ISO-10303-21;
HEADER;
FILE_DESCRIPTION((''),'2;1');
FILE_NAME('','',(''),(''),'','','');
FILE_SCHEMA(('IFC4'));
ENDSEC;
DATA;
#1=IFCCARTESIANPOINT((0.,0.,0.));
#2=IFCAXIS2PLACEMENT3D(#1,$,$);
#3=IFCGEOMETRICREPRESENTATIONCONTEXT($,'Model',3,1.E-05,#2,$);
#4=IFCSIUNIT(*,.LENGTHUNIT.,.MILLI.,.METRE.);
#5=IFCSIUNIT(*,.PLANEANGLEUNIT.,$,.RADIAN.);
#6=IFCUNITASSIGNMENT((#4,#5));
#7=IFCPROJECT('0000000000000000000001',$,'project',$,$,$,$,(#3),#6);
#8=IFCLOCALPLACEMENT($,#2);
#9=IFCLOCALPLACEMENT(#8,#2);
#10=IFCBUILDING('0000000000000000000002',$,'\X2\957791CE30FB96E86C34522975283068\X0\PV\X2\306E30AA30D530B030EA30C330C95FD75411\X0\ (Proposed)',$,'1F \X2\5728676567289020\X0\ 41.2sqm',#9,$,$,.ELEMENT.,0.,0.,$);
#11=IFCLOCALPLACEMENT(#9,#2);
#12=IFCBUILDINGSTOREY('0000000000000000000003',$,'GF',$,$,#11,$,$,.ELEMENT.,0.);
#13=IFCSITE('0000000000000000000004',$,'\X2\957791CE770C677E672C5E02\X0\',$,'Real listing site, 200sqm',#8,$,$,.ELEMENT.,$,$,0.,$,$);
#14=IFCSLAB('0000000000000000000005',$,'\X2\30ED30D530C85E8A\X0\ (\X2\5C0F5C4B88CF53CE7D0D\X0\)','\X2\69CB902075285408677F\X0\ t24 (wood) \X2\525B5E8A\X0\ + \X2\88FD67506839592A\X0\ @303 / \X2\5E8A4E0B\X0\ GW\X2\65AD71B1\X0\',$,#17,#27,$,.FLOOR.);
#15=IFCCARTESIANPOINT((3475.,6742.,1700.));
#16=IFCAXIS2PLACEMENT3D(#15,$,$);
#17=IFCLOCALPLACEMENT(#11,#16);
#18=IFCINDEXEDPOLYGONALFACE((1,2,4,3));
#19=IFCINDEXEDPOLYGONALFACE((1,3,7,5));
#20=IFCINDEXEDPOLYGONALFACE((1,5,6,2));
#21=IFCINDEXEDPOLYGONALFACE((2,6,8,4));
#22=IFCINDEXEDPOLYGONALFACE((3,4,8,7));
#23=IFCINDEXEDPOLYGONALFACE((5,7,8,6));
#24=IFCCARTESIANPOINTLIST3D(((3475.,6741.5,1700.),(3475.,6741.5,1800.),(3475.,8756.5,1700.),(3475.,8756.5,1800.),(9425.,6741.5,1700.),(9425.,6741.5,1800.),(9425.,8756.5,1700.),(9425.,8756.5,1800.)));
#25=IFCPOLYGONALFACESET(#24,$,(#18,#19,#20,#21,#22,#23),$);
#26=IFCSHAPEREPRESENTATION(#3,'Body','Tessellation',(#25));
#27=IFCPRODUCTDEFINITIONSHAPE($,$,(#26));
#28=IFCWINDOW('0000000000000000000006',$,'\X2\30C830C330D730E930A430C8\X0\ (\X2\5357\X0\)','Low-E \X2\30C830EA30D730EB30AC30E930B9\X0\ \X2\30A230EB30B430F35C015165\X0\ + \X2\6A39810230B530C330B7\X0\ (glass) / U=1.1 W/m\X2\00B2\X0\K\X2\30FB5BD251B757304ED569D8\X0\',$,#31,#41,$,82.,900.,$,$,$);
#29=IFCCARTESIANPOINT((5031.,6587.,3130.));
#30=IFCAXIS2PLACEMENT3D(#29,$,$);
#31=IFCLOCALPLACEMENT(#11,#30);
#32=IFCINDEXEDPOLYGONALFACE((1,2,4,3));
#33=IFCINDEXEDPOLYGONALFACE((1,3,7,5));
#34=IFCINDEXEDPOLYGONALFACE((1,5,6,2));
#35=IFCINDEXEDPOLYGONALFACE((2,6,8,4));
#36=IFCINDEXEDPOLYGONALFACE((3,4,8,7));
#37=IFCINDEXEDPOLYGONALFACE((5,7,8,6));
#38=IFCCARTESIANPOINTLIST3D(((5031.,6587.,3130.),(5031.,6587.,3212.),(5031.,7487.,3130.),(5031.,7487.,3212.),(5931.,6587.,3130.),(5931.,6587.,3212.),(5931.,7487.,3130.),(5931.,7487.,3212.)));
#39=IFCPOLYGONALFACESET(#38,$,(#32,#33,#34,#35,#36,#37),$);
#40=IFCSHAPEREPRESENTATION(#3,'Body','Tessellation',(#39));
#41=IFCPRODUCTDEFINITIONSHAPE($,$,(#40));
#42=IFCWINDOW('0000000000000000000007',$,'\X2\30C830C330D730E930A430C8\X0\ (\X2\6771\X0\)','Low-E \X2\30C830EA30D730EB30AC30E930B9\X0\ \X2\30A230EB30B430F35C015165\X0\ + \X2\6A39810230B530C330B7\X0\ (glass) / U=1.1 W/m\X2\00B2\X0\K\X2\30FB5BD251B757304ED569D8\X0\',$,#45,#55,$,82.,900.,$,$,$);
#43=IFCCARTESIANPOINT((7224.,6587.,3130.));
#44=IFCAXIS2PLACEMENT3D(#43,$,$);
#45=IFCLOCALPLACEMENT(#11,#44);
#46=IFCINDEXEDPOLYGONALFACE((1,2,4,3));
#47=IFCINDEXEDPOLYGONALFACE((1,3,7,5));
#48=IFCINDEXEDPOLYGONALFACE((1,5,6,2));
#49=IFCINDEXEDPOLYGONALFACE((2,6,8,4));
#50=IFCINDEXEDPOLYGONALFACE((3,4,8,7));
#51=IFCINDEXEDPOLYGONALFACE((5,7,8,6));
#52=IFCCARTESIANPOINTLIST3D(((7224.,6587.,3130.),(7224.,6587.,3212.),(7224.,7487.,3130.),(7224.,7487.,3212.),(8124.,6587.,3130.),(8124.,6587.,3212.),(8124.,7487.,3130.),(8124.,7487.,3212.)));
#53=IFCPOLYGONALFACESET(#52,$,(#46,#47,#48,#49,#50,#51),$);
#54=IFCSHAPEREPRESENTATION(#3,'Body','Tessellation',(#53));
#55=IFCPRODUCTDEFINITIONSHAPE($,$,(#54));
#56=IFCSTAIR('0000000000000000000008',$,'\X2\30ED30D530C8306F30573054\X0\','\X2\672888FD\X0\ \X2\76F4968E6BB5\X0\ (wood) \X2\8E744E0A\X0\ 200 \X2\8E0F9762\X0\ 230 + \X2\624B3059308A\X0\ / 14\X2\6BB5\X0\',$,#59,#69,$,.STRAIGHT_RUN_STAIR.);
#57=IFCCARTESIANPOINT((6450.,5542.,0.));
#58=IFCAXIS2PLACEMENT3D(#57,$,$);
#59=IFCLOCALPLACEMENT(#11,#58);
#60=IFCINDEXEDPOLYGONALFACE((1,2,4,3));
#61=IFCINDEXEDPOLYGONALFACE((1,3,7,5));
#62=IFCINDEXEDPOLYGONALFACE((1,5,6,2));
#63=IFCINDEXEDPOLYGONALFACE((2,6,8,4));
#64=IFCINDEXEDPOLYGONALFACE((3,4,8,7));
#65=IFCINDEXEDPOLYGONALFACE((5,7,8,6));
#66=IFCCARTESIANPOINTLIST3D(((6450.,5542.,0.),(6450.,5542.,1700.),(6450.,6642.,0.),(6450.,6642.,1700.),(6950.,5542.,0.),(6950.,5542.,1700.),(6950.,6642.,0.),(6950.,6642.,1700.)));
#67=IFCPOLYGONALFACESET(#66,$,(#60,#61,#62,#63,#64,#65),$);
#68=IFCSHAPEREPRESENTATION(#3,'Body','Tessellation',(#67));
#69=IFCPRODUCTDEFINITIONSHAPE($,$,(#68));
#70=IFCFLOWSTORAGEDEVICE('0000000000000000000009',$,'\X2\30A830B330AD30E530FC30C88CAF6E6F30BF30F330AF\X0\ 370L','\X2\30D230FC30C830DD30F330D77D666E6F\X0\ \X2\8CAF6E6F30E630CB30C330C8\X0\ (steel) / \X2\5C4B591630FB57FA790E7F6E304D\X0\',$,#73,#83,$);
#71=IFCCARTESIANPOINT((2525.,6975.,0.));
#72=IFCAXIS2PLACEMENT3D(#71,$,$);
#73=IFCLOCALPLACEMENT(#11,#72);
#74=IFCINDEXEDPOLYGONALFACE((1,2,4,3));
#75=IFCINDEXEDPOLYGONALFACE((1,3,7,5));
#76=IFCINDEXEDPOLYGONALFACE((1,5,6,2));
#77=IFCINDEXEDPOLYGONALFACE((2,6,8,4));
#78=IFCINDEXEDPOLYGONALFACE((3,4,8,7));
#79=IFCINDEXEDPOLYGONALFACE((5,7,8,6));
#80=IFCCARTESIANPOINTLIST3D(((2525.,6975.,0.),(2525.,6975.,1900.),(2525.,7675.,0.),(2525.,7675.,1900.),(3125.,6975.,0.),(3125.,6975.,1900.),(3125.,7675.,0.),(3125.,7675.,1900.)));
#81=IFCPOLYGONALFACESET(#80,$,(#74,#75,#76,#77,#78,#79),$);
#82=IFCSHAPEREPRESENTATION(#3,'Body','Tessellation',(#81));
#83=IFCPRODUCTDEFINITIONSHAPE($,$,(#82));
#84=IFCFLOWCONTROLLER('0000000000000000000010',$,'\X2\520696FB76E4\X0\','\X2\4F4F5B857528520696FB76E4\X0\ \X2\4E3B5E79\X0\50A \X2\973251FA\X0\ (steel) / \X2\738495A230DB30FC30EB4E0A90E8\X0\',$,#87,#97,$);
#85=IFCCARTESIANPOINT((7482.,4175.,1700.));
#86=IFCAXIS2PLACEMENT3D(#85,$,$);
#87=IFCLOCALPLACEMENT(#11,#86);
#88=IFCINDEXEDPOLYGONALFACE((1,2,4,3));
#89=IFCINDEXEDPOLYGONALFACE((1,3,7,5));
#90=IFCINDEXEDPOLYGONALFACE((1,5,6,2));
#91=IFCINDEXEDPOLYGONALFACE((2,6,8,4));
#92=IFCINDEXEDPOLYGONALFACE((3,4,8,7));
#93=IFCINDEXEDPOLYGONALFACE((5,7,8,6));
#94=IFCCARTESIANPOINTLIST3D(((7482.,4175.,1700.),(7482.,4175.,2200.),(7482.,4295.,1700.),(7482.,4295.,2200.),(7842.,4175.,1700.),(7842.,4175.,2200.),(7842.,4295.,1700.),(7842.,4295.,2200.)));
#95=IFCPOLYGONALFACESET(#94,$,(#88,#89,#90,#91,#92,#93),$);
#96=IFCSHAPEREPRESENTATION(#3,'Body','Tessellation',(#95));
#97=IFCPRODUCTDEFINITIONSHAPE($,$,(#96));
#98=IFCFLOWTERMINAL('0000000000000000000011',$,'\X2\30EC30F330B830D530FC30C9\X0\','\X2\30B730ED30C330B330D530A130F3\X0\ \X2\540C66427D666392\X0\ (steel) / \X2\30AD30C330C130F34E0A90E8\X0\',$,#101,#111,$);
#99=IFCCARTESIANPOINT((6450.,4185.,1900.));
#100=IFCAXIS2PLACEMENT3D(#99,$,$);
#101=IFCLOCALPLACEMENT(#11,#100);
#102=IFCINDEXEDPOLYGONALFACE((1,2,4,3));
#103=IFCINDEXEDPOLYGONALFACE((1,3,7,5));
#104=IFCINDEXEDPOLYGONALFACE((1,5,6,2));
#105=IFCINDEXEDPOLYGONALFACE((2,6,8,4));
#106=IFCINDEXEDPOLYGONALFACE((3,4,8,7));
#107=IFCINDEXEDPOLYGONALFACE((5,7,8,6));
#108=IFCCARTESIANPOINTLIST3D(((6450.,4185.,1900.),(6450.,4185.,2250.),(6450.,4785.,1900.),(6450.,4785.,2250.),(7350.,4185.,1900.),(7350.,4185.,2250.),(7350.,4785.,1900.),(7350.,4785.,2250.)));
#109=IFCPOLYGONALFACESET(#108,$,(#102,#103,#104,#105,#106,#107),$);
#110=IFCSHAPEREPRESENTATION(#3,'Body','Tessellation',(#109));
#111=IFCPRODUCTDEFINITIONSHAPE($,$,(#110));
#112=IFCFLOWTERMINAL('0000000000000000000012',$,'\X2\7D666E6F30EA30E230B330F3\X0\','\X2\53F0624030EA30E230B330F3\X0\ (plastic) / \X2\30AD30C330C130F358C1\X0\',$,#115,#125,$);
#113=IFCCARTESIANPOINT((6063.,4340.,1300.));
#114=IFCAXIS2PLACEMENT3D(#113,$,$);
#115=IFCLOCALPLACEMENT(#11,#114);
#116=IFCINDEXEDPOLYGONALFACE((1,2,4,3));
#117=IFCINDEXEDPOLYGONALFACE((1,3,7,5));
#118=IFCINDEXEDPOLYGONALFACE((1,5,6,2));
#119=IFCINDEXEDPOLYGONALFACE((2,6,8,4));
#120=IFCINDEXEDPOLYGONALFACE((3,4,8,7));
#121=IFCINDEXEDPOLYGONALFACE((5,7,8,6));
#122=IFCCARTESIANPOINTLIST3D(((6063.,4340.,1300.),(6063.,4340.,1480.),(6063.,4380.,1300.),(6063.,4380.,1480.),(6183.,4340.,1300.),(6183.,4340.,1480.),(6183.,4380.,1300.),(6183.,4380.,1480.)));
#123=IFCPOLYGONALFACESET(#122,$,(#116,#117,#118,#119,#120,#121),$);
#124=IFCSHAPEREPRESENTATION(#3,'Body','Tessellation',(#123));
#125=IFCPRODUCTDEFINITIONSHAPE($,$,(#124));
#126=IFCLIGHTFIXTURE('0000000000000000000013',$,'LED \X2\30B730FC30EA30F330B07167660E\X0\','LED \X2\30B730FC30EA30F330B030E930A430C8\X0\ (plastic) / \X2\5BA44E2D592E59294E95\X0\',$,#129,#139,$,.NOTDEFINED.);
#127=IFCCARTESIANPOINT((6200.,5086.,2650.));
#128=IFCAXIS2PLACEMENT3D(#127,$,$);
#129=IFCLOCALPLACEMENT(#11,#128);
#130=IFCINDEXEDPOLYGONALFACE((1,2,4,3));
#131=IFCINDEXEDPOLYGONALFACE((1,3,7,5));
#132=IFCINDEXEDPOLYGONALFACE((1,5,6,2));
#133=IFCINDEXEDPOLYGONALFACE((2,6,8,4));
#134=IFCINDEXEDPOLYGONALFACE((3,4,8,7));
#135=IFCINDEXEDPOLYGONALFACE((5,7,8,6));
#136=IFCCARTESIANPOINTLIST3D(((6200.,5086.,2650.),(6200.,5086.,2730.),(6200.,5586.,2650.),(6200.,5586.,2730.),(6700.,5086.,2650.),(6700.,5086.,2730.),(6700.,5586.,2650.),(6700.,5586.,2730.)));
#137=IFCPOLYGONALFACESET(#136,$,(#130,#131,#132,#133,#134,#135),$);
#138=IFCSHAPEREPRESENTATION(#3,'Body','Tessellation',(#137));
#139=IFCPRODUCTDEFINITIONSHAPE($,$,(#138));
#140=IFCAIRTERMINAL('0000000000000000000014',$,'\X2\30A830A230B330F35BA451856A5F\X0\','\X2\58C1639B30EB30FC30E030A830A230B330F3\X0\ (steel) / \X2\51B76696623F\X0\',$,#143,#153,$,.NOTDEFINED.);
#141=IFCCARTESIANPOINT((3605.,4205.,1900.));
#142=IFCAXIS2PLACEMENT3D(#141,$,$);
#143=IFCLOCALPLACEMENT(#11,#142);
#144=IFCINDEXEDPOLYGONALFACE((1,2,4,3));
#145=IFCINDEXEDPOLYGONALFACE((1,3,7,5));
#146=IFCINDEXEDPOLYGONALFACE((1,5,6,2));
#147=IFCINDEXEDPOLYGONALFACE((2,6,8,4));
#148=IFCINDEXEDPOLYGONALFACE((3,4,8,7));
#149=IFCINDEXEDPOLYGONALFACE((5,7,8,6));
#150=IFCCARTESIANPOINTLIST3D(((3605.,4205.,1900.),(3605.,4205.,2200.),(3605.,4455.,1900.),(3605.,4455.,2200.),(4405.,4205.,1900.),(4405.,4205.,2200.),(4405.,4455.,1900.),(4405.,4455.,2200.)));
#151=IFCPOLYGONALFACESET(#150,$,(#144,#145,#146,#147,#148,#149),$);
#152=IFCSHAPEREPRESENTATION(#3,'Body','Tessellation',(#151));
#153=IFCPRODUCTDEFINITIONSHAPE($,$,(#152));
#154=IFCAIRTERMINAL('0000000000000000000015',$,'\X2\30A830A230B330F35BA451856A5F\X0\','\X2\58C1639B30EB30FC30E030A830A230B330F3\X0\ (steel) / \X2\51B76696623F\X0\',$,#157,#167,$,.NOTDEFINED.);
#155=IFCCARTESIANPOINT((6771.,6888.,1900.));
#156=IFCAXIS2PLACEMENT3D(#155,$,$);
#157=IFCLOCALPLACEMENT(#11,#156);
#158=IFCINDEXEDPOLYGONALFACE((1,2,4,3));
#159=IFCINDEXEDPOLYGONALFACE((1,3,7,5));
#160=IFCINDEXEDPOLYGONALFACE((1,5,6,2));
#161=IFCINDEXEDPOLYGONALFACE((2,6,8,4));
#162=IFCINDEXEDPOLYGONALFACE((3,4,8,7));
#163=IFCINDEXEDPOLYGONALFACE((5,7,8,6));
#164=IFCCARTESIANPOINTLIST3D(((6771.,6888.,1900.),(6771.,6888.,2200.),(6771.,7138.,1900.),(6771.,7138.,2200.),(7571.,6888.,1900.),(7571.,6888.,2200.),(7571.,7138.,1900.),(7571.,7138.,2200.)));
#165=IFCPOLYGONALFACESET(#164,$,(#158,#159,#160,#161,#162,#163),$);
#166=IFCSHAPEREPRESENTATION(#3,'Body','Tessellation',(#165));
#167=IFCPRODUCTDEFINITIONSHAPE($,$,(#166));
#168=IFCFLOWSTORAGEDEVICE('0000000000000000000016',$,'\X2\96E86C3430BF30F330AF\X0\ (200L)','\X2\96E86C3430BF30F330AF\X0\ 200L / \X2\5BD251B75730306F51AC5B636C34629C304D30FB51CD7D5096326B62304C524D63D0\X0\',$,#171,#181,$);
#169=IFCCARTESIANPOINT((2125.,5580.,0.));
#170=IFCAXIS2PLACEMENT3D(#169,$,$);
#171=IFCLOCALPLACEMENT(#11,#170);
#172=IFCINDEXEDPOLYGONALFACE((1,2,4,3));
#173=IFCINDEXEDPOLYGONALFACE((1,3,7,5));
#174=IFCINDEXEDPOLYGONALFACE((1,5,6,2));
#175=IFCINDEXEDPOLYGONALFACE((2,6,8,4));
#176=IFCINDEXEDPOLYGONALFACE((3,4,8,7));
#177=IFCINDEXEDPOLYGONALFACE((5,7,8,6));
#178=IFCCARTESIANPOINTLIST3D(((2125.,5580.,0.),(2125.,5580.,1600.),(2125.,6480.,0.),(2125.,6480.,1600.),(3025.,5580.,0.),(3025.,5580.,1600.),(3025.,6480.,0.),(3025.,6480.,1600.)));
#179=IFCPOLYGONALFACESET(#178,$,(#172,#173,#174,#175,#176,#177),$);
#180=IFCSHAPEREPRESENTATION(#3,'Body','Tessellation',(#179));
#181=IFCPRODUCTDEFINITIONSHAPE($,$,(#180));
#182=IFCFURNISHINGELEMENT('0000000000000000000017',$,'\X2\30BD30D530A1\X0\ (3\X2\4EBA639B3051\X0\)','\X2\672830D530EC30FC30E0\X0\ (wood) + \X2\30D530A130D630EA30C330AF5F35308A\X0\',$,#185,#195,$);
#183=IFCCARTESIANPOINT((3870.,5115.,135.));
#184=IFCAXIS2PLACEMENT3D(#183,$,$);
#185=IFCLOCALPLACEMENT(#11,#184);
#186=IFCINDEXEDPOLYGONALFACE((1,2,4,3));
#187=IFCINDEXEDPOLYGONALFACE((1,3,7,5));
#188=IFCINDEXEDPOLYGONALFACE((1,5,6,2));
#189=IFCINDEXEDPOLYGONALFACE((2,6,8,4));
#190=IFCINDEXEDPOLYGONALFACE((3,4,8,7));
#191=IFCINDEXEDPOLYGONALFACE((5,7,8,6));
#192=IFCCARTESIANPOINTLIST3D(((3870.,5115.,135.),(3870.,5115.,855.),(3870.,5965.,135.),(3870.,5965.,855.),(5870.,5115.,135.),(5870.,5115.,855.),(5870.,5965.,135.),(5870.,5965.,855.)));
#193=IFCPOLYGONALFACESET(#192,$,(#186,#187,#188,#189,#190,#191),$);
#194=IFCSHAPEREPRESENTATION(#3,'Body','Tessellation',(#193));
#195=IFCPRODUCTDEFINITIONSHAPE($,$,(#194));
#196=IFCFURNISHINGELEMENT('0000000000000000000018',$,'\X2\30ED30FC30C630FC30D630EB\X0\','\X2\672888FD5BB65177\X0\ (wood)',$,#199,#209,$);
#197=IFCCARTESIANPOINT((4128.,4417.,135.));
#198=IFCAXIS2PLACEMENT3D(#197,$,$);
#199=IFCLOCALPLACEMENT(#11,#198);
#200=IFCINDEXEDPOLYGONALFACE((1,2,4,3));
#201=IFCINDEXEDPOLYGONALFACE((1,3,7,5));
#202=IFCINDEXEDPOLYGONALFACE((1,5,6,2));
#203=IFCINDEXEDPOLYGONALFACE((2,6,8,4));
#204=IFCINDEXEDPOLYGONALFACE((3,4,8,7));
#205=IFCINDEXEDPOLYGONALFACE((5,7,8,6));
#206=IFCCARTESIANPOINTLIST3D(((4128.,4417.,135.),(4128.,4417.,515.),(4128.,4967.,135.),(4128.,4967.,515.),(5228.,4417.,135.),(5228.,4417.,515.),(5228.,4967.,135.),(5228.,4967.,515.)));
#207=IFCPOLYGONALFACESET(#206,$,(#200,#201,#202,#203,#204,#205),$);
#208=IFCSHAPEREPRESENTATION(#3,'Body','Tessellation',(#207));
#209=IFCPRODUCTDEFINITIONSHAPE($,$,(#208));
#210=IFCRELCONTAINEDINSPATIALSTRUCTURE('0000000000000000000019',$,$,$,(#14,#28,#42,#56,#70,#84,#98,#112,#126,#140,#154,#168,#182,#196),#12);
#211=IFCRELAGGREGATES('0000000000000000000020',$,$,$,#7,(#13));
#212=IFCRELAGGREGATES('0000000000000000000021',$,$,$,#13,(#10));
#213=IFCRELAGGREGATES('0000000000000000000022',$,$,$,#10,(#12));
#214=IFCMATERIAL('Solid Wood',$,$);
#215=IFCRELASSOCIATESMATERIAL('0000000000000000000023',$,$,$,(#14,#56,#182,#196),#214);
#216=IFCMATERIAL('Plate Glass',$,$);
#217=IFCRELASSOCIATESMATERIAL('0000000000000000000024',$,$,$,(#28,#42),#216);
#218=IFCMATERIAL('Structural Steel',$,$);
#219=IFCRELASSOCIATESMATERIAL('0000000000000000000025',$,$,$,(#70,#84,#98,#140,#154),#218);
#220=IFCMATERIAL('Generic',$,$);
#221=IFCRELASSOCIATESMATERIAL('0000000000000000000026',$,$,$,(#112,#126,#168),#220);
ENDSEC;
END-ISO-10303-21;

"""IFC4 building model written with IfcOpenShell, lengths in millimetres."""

from ifc_helpers import new_model, si_unit, frame, frame_2d, origin, place, context, project, spatial, rectangle, extrude, material, element, save


model = new_model("IFC4")

# Units and contexts
model_context = context("Model", 3, precision=1e-05, world=origin())
ifc_project = project(units=[si_unit("LENGTHUNIT", "METRE", prefix="MILLI"), si_unit("PLANEANGLEUNIT", "RADIAN")], contexts=[model_context])

# Site, building, storey
site_placement = place(None, origin())
site = spatial("IfcSite", under=ifc_project, at=site_placement, Name="長野県松本市", ObjectType="Real listing site, 200sqm", CompositionType="ELEMENT", RefElevation=0.0)
building_placement = place(site_placement, origin())
building = spatial("IfcBuilding", under=site, at=building_placement, Name="長野・雨水利用とPVのオフグリッド志向 (Proposed)", ObjectType="1F 在来木造 41.2sqm", CompositionType="ELEMENT", ElevationOfRefHeight=0.0, ElevationOfTerrain=0.0)
storey_placement = place(building_placement, origin())
storey = spatial("IfcBuildingStorey", under=building, at=storey_placement, Name="GF", CompositionType="ELEMENT", Elevation=0.0)

# Shared definitions
ifc_material_1 = material(Name="Solid Wood")

# Slab
slab_placement = place(storey_placement, frame((3475.0, 6742.0, 1700.0)))
element("IfcSlab", 1, at=slab_placement, inside=storey, material=ifc_material_1, Name="ロフト床 (小屋裏収納)", Description="構造用合板 t24 (wood) 剛床 + 製材根太 @303 / 床下 GW断熱", PredefinedType="FLOOR", context=model_context, shape_type="SweptSolid", body=[
    extrude(rectangle(XDim=5950.0, YDim=2015.0, at=frame_2d((2975.0, 1007.0))), frame((3475.0, 6742.0, 1700.0)), (0.0, 0.0, 1.0), 100.0),
])

# Windows
ifc_material_2 = material(Name="Plate Glass")
window_1_placement = place(storey_placement, frame((5031.0, 6587.0, 3130.0)))
element("IfcWindow", 2, at=window_1_placement, inside=storey, material=ifc_material_2, Name="トップライト (南)", Description="Low-E トリプルガラス アルゴン封入 + 樹脂サッシ (glass) / U=1.1 W/m²K・寒冷地仕様", OverallHeight=82.0, OverallWidth=900.0, context=model_context, shape_type="SweptSolid", body=[
    extrude(rectangle(XDim=900.0, YDim=900.0, at=frame_2d((450.0, 450.0))), frame((5031.0, 6587.0, 3130.0)), (0.0, 0.0, 1.0), 82.0),
])
window_2_placement = place(storey_placement, frame((7224.0, 6587.0, 3130.0)))
element("IfcWindow", 3, at=window_2_placement, inside=storey, material=ifc_material_2, Name="トップライト (東)", Description="Low-E トリプルガラス アルゴン封入 + 樹脂サッシ (glass) / U=1.1 W/m²K・寒冷地仕様", OverallHeight=82.0, OverallWidth=900.0, context=model_context, shape_type="SweptSolid", body=[
    extrude(rectangle(XDim=900.0, YDim=900.0, at=frame_2d((450.0, 450.0))), frame((7224.0, 6587.0, 3130.0)), (0.0, 0.0, 1.0), 82.0),
])

# Stair
stair_placement = place(storey_placement, frame((6450.0, 5542.0, 0.0)))
element("IfcStair", 4, at=stair_placement, inside=storey, material=ifc_material_1, Name="ロフトはしご", Description="木製 直階段 (wood) 蹴上 200 踏面 230 + 手すり / 14段", PredefinedType="STRAIGHT_RUN_STAIR", context=model_context, shape_type="SweptSolid", body=[
    extrude(rectangle(XDim=500.0, YDim=1100.0, at=frame_2d((250.0, 550.0))), frame((6450.0, 5542.0, 0.0)), (0.0, 0.0, 1.0), 1700.0),
])

# Flow storage device
ifc_material_3 = material(Name="Structural Steel")
flow_storage_device_1_placement = place(storey_placement, frame((2525.0, 6975.0, 0.0)))
element("IfcFlowStorageDevice", 5, at=flow_storage_device_1_placement, inside=storey, material=ifc_material_3, Name="エコキュート貯湯タンク 370L", Description="ヒートポンプ給湯 貯湯ユニット (steel) / 屋外・基礎置き", context=model_context, shape_type="SweptSolid", body=[
    extrude(rectangle(XDim=600.0, YDim=700.0, at=frame_2d((300.0, 350.0))), frame((2525.0, 6975.0, 0.0)), (0.0, 0.0, 1.0), 1900.0),
])

# Flow controller
flow_controller_placement = place(storey_placement, frame((7482.0, 4175.0, 1700.0)))
element("IfcFlowController", 6, at=flow_controller_placement, inside=storey, material=ifc_material_3, Name="分電盤", Description="住宅用分電盤 主幹50A 露出 (steel) / 玄関ホール上部", context=model_context, shape_type="SweptSolid", body=[
    extrude(rectangle(XDim=360.0, YDim=120.0, at=frame_2d((180.0, 60.0))), frame((7482.0, 4175.0, 1700.0)), (0.0, 0.0, 1.0), 500.0),
])

# Flow terminals
flow_terminal_1_placement = place(storey_placement, frame((6450.0, 4185.0, 1900.0)))
element("IfcFlowTerminal", 7, at=flow_terminal_1_placement, inside=storey, material=ifc_material_3, Name="レンジフード", Description="シロッコファン 同時給排 (steel) / キッチン上部", context=model_context, shape_type="SweptSolid", body=[
    extrude(rectangle(XDim=900.0, YDim=600.0, at=frame_2d((450.0, 300.0))), frame((6450.0, 4185.0, 1900.0)), (0.0, 0.0, 1.0), 350.0),
])
ifc_material_4 = material(Name="Generic")
flow_terminal_2_placement = place(storey_placement, frame((6063.0, 4340.0, 1300.0)))
element("IfcFlowTerminal", 8, at=flow_terminal_2_placement, inside=storey, material=ifc_material_4, Name="給湯リモコン", Description="台所リモコン (plastic) / キッチン壁", context=model_context, shape_type="SweptSolid", body=[
    extrude(rectangle(XDim=120.0, YDim=40.0, at=frame_2d((60.0, 20.0))), frame((6063.0, 4340.0, 1300.0)), (0.0, 0.0, 1.0), 180.0),
])

# Light fixture
light_fixture_placement = place(storey_placement, frame((6200.0, 5086.0, 2650.0)))
element("IfcLightFixture", 9, at=light_fixture_placement, inside=storey, material=ifc_material_4, Name="LED シーリング照明", Description="LED シーリングライト (plastic) / 室中央天井", PredefinedType="NOTDEFINED", context=model_context, shape_type="SweptSolid", body=[
    extrude(rectangle(XDim=500.0, YDim=500.0, at=frame_2d((250.0, 250.0))), frame((6200.0, 5086.0, 2650.0)), (0.0, 0.0, 1.0), 80.0),
])

# Air terminals
air_terminal_1_placement = place(storey_placement, frame((3605.0, 4205.0, 1900.0)))
element("IfcAirTerminal", 10, at=air_terminal_1_placement, inside=storey, material=ifc_material_3, Name="エアコン室内機", Description="壁掛ルームエアコン (steel) / 冷暖房", PredefinedType="NOTDEFINED", context=model_context, shape_type="SweptSolid", body=[
    extrude(rectangle(XDim=800.0, YDim=250.0, at=frame_2d((400.0, 125.0))), frame((3605.0, 4205.0, 1900.0)), (0.0, 0.0, 1.0), 300.0),
])
air_terminal_2_placement = place(storey_placement, frame((6771.0, 6888.0, 1900.0)))
element("IfcAirTerminal", 11, at=air_terminal_2_placement, inside=storey, material=ifc_material_3, Name="エアコン室内機", Description="壁掛ルームエアコン (steel) / 冷暖房", PredefinedType="NOTDEFINED", context=model_context, shape_type="SweptSolid", body=[
    extrude(rectangle(XDim=800.0, YDim=250.0, at=frame_2d((400.0, 125.0))), frame((6771.0, 6888.0, 1900.0)), (0.0, 0.0, 1.0), 300.0),
])

# Flow storage device
flow_storage_device_2_placement = place(storey_placement, frame((2125.0, 5580.0, 0.0)))
element("IfcFlowStorageDevice", 12, at=flow_storage_device_2_placement, inside=storey, material=ifc_material_4, Name="雨水タンク (200L)", Description="雨水タンク 200L / 寒冷地は冬季水抜き・凍結防止が前提", context=model_context, shape_type="SweptSolid", body=[
    extrude(rectangle(XDim=900.0, YDim=900.0, at=frame_2d((450.0, 450.0))), frame((2125.0, 5580.0, 0.0)), (0.0, 0.0, 1.0), 1600.0),
])

# Furnishing elements
furnishing_1_placement = place(storey_placement, frame((3870.0, 5115.0, 135.0)))
element("IfcFurnishingElement", 13, at=furnishing_1_placement, inside=storey, material=ifc_material_1, Name="ソファ (3人掛け)", Description="木フレーム (wood) + ファブリック張り", context=model_context, shape_type="SweptSolid", body=[
    extrude(rectangle(XDim=2000.0, YDim=850.0, at=frame_2d((1000.0, 425.0))), frame((3870.0, 5115.0, 135.0)), (0.0, 0.0, 1.0), 720.0),
])
furnishing_2_placement = place(storey_placement, frame((4128.0, 4417.0, 135.0)))
element("IfcFurnishingElement", 14, at=furnishing_2_placement, inside=storey, material=ifc_material_1, Name="ローテーブル", Description="木製家具 (wood)", context=model_context, shape_type="SweptSolid", body=[
    extrude(rectangle(XDim=1100.0, YDim=550.0, at=frame_2d((550.0, 275.0))), frame((4128.0, 4417.0, 135.0)), (0.0, 0.0, 1.0), 380.0),
])

save(model, "model.ifc")
